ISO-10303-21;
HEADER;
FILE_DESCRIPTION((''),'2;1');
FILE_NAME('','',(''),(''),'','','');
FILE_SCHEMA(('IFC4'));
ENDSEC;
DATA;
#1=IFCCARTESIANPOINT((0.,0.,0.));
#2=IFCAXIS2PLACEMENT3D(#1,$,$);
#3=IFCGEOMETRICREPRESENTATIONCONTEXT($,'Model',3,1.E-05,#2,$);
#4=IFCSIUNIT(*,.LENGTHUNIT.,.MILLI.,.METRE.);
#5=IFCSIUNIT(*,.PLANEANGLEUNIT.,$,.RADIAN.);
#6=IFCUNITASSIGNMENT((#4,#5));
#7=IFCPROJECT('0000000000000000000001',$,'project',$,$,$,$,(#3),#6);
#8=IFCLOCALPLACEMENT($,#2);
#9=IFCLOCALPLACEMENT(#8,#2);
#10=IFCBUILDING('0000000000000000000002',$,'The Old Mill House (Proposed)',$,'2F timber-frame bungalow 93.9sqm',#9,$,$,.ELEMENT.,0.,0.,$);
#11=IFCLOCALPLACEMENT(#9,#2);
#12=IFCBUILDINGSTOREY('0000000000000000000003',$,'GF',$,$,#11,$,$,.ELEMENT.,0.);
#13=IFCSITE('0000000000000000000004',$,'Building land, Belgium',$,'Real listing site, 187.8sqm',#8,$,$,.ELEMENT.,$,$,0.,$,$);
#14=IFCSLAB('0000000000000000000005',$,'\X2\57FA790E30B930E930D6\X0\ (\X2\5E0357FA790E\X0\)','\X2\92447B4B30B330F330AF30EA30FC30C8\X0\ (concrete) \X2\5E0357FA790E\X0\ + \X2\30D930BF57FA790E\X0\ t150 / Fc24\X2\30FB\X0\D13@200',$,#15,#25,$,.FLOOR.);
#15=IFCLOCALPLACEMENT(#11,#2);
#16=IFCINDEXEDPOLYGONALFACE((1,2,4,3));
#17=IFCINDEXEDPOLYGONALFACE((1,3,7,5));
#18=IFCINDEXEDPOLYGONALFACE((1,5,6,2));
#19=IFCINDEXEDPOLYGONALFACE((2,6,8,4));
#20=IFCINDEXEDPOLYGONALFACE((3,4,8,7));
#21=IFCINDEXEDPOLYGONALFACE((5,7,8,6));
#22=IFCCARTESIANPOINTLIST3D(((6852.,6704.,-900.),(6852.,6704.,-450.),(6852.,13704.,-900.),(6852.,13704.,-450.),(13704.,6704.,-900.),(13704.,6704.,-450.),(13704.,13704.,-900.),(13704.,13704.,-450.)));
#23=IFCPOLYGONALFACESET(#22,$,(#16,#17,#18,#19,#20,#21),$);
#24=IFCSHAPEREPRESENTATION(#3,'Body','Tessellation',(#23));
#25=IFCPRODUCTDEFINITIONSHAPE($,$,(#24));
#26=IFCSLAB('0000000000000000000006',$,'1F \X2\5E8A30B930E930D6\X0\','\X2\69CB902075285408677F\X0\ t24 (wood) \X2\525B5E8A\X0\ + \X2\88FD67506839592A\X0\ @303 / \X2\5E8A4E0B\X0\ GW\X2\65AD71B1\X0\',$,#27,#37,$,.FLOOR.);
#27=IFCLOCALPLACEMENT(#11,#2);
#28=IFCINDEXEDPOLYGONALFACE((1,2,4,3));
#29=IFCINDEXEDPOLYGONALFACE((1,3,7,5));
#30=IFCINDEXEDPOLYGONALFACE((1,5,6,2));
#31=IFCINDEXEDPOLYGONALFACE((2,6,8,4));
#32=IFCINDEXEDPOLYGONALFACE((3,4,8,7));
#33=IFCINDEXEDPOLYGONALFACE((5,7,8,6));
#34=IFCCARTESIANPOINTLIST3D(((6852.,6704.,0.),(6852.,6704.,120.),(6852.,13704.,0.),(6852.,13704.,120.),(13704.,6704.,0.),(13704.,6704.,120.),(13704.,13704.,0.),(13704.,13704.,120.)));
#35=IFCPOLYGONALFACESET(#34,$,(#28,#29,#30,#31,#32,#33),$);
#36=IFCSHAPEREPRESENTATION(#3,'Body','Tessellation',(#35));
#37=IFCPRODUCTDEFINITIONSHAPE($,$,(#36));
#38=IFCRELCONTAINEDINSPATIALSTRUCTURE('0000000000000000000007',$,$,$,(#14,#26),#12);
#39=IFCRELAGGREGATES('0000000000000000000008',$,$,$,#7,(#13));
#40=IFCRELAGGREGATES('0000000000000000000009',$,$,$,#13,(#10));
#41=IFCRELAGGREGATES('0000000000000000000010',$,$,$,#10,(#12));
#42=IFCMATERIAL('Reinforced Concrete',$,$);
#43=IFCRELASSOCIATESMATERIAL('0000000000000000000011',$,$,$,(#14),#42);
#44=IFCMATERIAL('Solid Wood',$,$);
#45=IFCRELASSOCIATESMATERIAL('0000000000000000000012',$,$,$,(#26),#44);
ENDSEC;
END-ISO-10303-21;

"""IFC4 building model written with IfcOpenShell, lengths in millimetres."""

from ifc_helpers import new_model, si_unit, frame, frame_2d, origin, place, context, project, spatial, rectangle, extrude, material, element, save


model = new_model("IFC4")

# Units and contexts
model_context = context("Model", 3, precision=1e-05, world=origin())
ifc_project = project(units=[si_unit("LENGTHUNIT", "METRE", prefix="MILLI"), si_unit("PLANEANGLEUNIT", "RADIAN")], contexts=[model_context])

# Site, building, storey
site_placement = place(None, origin())
site = spatial("IfcSite", under=ifc_project, at=site_placement, Name="Building land, Belgium", ObjectType="Real listing site, 187.8sqm", CompositionType="ELEMENT", RefElevation=0.0)
building_placement = place(site_placement, origin())
building = spatial("IfcBuilding", under=site, at=building_placement, Name="The Old Mill House (Proposed)", ObjectType="2F timber-frame bungalow 93.9sqm", CompositionType="ELEMENT", ElevationOfRefHeight=0.0, ElevationOfTerrain=0.0)
storey_placement = place(building_placement, origin())
storey = spatial("IfcBuildingStorey", under=building, at=storey_placement, Name="GF", CompositionType="ELEMENT", Elevation=0.0)

# Slabs
ifc_material_1 = material(Name="Reinforced Concrete")
slab_1_placement = place(storey_placement, frame((3426.0, 3352.0, -450.0)))
element("IfcSlab", 1, at=slab_1_placement, inside=storey, material=ifc_material_1, Name="基礎スラブ (布基礎)", Description="鉄筋コンクリート (concrete) 布基礎 + ベタ基礎 t150 / Fc24・D13@200", PredefinedType="FLOOR", context=model_context, shape_type="SweptSolid", body=[
    extrude(rectangle(XDim=6852.0, YDim=7000.0, at=frame_2d((3426.0, 3500.0))), frame((3426.0, 3352.0, -450.0)), (0.0, 0.0, 1.0), 450.0),
])
ifc_material_2 = material(Name="Solid Wood")
slab_2_placement = place(storey_placement, frame((3426.0, 3352.0, 0.0)))
element("IfcSlab", 2, at=slab_2_placement, inside=storey, material=ifc_material_2, Name="1F 床スラブ", Description="構造用合板 t24 (wood) 剛床 + 製材根太 @303 / 床下 GW断熱", PredefinedType="FLOOR", context=model_context, shape_type="SweptSolid", body=[
    extrude(rectangle(XDim=6852.0, YDim=7000.0, at=frame_2d((3426.0, 3500.0))), frame((3426.0, 3352.0, 0.0)), (0.0, 0.0, 1.0), 120.0),
])

save(model, "model.ifc")
